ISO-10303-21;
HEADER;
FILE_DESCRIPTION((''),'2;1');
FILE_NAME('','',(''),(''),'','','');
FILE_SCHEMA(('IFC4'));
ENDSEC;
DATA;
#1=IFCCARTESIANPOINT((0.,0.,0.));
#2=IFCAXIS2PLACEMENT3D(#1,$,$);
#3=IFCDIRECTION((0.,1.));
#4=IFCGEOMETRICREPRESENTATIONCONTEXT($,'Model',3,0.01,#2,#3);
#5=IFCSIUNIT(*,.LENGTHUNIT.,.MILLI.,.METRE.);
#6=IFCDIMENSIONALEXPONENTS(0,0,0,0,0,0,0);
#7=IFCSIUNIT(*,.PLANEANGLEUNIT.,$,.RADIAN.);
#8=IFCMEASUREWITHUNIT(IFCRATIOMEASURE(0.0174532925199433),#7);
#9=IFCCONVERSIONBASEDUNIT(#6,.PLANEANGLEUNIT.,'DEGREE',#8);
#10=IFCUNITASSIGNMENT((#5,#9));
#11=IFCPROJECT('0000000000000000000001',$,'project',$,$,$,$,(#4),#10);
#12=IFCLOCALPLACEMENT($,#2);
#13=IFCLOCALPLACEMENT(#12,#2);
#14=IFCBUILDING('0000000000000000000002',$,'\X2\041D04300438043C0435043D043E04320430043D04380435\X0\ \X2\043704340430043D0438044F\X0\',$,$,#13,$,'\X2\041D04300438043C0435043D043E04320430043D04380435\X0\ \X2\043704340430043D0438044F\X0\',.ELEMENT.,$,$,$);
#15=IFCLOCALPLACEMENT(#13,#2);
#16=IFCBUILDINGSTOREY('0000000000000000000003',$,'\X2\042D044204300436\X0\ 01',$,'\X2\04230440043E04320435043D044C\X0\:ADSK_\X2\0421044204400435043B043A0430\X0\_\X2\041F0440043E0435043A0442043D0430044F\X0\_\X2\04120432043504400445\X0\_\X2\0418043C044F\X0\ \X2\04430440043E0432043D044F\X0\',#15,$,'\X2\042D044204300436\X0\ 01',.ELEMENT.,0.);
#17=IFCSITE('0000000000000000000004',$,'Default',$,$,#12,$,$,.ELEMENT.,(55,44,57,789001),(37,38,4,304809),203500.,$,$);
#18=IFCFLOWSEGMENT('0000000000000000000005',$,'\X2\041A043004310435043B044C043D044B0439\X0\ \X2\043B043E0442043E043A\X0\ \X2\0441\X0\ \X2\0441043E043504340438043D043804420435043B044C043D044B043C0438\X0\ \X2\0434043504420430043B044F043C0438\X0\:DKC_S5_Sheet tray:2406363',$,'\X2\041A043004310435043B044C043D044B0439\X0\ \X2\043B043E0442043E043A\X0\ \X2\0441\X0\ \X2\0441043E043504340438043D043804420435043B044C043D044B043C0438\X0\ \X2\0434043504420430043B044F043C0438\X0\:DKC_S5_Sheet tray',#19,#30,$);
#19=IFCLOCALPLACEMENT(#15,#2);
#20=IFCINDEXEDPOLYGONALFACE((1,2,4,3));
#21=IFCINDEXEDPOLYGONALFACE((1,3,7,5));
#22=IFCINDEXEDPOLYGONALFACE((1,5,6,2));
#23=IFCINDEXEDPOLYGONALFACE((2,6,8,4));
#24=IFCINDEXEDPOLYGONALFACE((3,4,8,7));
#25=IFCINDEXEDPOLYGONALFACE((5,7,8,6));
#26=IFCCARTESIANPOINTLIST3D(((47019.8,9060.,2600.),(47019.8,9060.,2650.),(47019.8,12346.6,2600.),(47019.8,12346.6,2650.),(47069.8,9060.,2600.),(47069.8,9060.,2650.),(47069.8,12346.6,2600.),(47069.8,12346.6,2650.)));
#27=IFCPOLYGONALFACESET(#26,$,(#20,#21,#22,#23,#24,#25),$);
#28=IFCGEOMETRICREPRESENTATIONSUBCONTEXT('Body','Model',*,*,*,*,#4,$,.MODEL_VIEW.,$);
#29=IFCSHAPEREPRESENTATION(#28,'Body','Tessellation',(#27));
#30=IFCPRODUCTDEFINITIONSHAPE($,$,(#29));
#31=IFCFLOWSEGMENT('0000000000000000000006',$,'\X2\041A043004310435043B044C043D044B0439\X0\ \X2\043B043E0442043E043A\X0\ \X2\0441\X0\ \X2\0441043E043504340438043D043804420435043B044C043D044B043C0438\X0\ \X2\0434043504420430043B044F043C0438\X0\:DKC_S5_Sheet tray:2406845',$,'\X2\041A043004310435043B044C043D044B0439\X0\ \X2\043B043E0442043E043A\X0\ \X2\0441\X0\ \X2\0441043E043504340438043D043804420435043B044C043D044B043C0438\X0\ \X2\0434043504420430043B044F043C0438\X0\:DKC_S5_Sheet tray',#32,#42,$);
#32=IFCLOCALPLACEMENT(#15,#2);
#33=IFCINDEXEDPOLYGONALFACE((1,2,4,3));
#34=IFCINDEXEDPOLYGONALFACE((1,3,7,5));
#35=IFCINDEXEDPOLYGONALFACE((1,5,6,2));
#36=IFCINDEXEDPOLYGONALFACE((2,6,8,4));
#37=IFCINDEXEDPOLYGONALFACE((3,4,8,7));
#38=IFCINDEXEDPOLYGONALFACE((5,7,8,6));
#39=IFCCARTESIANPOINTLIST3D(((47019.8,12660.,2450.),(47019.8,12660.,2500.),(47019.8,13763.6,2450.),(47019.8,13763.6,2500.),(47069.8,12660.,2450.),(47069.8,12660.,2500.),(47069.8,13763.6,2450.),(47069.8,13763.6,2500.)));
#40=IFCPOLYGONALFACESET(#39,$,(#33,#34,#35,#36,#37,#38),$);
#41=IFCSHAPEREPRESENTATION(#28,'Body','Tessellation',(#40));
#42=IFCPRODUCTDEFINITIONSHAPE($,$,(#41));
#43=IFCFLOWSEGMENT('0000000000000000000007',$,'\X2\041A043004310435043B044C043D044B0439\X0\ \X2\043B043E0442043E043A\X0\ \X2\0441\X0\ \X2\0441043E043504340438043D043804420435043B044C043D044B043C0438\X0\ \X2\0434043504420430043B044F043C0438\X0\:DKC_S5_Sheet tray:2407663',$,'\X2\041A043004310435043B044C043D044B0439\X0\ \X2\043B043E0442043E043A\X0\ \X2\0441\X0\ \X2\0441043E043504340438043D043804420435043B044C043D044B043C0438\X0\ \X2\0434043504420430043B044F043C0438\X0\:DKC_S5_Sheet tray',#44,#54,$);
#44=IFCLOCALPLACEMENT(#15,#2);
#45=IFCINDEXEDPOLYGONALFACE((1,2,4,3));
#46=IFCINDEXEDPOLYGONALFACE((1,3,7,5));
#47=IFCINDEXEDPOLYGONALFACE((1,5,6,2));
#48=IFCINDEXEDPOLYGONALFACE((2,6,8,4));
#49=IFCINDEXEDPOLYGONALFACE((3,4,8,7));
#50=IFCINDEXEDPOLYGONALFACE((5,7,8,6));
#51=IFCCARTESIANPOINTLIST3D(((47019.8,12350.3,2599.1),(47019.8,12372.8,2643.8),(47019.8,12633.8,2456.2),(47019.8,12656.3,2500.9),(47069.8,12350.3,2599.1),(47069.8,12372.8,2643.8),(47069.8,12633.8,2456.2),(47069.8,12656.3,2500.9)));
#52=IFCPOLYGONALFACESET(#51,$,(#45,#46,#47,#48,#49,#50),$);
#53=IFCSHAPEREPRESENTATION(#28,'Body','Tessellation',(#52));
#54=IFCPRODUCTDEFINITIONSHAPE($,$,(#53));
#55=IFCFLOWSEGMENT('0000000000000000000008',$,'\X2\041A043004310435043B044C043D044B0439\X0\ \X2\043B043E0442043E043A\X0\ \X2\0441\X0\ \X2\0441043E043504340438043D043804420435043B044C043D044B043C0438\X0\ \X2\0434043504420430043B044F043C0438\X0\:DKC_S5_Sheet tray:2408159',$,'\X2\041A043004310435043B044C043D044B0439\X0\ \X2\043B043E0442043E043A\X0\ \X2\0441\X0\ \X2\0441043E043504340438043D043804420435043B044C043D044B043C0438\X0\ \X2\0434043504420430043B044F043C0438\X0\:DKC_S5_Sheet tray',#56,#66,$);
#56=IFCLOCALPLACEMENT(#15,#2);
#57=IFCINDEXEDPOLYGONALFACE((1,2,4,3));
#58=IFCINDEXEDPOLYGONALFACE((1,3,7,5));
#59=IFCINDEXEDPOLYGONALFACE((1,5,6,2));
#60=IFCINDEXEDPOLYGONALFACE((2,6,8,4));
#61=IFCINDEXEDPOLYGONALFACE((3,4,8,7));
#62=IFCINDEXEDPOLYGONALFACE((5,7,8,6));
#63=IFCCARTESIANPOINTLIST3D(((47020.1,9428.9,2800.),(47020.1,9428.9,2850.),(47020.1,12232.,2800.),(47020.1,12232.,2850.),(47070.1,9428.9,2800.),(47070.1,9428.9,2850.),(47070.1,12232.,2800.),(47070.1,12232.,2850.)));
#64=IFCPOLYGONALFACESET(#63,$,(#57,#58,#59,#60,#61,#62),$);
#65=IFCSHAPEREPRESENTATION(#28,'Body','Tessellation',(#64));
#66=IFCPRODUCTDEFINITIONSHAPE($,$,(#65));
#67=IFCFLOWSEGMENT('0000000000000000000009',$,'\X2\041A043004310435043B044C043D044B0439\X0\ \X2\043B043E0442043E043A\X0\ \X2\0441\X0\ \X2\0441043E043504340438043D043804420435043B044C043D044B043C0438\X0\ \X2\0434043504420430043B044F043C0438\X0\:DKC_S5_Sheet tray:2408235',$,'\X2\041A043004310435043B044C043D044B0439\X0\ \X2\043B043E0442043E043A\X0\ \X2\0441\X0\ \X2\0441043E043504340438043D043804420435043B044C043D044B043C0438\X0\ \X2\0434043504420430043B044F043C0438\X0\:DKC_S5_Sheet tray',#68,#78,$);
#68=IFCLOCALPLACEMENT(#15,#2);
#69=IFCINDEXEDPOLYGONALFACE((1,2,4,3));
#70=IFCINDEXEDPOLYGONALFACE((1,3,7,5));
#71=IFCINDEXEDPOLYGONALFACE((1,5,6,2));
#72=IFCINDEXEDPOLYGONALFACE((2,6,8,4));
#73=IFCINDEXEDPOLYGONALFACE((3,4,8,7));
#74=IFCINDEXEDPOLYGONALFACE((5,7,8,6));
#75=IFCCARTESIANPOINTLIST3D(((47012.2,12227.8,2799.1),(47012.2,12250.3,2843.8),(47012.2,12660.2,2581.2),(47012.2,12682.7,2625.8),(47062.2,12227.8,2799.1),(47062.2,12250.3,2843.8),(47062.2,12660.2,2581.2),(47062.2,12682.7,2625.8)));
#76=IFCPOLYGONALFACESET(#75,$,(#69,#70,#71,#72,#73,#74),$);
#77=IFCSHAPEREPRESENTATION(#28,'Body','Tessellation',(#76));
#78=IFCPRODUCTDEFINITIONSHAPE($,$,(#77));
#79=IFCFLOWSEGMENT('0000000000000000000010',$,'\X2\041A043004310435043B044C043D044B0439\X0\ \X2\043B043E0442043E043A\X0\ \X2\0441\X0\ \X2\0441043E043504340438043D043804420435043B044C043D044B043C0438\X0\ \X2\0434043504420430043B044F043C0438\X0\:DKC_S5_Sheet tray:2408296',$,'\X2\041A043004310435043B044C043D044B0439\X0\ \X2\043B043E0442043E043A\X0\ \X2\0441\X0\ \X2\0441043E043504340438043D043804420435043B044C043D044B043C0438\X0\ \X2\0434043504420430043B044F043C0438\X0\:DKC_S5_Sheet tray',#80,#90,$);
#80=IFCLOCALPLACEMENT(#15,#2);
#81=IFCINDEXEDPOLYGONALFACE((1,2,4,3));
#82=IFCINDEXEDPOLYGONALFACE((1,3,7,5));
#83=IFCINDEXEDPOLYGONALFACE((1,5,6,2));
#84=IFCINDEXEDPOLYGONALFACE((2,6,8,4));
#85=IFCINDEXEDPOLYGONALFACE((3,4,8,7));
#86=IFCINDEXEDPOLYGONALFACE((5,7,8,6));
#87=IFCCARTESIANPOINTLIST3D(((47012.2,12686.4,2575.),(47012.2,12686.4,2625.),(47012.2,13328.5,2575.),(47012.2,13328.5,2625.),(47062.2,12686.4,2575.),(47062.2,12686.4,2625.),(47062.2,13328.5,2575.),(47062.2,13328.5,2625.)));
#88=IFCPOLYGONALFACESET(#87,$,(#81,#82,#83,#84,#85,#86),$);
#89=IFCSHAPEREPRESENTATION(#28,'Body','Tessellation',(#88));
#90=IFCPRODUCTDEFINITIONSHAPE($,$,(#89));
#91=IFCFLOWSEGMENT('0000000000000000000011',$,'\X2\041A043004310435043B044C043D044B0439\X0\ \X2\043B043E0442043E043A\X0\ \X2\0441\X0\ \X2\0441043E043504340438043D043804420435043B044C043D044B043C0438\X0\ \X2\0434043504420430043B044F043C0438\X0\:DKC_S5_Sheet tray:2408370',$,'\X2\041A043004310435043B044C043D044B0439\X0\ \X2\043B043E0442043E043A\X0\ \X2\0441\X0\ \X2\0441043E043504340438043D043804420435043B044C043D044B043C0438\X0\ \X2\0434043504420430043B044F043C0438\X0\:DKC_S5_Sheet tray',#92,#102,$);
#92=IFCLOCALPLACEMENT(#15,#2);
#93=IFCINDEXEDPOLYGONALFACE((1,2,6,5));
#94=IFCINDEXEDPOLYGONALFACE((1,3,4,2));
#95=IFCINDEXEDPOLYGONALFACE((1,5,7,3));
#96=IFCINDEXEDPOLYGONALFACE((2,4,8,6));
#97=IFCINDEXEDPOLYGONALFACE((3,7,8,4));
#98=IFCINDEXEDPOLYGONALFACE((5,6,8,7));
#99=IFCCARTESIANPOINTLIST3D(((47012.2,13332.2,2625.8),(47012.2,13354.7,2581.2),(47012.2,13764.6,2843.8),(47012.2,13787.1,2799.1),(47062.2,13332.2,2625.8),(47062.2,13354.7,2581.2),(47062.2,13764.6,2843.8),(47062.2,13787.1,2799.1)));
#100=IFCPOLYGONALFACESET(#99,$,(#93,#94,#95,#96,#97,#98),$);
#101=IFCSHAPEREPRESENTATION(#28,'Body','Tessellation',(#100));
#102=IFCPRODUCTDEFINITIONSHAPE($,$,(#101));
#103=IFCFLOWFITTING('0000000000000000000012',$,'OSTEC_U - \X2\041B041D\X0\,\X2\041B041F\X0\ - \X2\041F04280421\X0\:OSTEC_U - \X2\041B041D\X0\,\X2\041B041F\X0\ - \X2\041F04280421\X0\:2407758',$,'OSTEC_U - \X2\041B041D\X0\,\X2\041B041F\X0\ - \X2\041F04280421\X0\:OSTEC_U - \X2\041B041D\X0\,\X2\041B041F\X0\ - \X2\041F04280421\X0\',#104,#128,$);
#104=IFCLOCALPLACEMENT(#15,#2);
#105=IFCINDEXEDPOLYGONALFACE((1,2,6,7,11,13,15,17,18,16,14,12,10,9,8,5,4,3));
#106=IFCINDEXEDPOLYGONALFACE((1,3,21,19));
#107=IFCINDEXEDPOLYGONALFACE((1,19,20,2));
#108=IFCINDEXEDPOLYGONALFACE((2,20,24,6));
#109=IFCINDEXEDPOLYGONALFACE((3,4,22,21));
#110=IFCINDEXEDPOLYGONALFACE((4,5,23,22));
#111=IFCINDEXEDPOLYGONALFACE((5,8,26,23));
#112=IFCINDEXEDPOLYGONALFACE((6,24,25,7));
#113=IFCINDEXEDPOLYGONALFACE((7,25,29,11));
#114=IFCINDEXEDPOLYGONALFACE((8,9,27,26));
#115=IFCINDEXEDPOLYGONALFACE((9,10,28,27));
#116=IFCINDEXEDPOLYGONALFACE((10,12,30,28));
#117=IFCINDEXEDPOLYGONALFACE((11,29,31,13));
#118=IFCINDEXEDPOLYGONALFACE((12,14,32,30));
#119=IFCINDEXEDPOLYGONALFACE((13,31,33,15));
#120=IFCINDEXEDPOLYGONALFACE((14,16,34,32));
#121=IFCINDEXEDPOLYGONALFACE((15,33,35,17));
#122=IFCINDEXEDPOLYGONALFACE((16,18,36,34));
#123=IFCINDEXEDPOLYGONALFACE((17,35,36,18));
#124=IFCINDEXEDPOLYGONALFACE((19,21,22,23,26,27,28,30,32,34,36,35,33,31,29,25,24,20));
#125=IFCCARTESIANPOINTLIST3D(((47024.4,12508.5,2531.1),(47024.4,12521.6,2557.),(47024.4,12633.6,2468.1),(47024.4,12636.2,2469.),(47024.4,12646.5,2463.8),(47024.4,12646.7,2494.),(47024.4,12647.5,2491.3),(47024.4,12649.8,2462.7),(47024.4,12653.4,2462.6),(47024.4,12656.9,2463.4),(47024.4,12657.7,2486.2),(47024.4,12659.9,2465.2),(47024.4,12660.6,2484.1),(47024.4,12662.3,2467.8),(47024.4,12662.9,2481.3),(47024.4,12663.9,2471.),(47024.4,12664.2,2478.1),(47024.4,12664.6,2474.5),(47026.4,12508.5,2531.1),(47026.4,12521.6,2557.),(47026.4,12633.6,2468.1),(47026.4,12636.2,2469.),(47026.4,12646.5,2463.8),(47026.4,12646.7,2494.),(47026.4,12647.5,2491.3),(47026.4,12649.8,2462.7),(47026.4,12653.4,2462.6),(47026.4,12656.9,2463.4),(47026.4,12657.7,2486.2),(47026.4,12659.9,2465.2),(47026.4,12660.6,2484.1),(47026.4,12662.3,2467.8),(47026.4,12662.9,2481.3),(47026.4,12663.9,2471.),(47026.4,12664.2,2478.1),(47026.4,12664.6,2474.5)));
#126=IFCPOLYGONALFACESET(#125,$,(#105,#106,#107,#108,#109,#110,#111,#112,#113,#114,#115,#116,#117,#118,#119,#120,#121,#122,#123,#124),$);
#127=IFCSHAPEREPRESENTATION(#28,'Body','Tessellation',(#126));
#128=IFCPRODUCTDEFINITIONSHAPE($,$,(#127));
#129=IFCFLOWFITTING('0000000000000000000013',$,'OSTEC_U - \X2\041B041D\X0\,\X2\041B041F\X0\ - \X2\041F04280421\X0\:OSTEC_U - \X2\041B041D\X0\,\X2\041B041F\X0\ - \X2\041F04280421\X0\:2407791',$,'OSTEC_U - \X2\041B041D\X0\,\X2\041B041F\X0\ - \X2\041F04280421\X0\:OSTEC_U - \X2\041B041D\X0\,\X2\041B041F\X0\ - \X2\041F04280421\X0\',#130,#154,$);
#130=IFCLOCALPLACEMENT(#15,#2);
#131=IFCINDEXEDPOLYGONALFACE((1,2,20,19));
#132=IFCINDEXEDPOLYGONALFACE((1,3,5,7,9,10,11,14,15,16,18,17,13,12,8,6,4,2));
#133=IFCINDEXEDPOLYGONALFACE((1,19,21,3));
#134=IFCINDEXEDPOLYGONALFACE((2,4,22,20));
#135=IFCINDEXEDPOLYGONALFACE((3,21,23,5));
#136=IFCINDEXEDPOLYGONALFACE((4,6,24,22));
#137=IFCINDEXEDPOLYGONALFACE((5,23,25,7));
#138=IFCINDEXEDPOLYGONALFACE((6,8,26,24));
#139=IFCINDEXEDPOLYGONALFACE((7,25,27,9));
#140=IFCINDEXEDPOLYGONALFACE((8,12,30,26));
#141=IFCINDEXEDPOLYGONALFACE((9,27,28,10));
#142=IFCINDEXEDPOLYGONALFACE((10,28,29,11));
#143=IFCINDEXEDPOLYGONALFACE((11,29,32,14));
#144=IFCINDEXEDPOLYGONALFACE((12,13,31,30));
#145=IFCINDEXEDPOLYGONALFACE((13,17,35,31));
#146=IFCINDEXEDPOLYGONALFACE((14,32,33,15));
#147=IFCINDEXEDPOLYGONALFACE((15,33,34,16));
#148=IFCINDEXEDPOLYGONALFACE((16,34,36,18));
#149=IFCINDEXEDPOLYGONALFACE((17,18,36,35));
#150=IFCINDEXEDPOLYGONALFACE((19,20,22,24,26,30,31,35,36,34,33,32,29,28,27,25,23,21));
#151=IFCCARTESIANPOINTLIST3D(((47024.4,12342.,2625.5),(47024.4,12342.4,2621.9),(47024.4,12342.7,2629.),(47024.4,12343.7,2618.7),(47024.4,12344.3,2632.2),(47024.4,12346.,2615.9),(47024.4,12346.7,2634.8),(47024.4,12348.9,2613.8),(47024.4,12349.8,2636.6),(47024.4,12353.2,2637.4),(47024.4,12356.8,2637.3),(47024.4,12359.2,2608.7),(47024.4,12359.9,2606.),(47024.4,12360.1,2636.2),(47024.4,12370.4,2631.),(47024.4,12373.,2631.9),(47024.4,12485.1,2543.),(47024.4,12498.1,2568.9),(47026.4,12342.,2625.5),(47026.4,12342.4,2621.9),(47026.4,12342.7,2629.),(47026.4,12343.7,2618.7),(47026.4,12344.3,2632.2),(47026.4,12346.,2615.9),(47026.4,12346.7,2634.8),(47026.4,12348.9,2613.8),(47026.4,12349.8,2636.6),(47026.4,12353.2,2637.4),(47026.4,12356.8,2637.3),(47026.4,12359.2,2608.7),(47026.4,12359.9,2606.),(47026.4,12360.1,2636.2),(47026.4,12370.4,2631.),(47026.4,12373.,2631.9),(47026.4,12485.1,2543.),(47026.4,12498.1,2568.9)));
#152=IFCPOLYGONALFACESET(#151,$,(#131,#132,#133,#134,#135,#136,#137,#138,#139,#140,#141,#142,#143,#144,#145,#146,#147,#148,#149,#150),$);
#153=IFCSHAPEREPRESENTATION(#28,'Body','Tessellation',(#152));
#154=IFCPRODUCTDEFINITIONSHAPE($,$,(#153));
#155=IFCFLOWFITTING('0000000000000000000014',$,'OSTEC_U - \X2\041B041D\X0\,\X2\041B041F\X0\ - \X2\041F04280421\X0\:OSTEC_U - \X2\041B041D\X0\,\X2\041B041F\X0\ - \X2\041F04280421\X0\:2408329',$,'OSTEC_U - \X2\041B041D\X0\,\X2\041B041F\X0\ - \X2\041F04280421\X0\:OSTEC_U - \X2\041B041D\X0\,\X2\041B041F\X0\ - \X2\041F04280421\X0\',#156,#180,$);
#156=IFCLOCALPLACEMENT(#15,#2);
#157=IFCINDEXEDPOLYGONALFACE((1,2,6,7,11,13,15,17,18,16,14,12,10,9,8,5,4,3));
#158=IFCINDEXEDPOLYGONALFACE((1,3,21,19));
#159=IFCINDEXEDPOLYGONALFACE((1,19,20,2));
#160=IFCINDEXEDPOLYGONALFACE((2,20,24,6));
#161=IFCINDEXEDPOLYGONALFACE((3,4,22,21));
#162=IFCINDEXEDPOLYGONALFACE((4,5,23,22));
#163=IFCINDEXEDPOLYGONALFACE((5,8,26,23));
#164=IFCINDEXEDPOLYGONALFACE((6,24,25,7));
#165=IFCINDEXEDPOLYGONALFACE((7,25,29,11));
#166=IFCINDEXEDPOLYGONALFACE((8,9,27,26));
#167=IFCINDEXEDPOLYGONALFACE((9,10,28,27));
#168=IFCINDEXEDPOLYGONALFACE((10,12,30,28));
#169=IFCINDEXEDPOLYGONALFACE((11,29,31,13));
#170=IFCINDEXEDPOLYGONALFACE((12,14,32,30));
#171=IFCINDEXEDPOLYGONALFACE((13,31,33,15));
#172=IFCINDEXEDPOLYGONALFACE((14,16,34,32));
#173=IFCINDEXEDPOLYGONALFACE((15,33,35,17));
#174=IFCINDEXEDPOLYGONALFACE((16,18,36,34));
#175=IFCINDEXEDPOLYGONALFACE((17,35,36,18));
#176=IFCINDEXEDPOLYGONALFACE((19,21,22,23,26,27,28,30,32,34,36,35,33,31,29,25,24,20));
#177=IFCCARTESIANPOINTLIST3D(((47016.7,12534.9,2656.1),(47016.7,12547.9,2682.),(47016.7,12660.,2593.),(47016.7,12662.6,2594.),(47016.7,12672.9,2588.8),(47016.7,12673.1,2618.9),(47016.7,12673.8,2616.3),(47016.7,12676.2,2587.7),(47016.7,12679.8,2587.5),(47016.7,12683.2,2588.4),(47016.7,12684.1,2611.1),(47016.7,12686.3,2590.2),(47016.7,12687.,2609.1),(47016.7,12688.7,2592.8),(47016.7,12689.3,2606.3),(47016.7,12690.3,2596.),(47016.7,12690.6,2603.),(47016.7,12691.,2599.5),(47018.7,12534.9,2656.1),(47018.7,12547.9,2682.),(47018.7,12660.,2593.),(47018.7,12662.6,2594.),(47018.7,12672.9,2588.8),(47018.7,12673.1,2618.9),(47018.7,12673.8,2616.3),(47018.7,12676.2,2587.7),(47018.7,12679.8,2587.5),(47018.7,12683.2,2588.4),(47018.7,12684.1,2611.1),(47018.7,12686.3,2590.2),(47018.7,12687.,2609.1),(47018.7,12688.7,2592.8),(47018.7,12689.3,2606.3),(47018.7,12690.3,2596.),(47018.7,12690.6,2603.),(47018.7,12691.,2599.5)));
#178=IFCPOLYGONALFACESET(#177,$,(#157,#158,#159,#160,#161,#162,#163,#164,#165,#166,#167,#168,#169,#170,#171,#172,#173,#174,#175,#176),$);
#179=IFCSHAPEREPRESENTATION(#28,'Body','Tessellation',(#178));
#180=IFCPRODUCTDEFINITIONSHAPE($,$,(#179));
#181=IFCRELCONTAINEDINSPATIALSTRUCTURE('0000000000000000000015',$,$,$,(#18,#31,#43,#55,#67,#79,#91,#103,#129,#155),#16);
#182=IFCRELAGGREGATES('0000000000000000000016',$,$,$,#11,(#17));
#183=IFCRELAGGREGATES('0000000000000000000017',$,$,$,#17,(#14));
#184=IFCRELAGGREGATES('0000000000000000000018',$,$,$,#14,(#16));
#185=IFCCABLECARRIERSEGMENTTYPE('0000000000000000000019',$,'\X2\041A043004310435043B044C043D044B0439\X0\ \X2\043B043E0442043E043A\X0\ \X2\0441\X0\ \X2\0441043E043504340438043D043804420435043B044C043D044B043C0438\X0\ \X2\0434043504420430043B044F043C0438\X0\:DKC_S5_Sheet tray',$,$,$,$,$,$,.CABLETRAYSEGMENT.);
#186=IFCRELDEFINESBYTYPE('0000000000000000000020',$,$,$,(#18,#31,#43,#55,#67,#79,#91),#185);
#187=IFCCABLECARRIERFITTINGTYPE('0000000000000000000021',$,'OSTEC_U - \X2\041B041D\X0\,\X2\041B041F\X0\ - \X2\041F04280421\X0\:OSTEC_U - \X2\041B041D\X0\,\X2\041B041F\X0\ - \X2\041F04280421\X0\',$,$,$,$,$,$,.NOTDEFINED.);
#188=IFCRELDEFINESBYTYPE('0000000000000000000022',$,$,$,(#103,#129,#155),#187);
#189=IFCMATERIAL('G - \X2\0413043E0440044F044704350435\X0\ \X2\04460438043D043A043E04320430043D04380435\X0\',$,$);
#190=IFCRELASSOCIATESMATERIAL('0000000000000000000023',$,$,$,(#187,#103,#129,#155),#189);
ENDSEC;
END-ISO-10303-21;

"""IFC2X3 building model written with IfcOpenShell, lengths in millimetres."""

from ifc_helpers import new_model, entity, si_unit, converted_unit, direction, frame, frame_2d, origin, origin_2d_with_axis, place, context, subcontext, project, spatial, polyline, circle_curve, parameter, trimmed, segment, composite_curve, rectangle, outline, extrude, source, transform, mapped, material, type_object, type_shapes, element, save


model = new_model("IFC2X3")

# Units and contexts
model_context = context("Model", 3, precision=0.01, world=origin(), true_north=direction((0.0, 1.0)))
body_context = subcontext(model_context, "Body", "Model", "MODEL_VIEW")
ifc_project = project(units=[si_unit("LENGTHUNIT", "METRE", prefix="MILLI"), converted_unit("PLANEANGLEUNIT", "DEGREE", entity("IfcRatioMeasure", 0.0174532925199433), si_unit("PLANEANGLEUNIT", "RADIAN"), dimensions=[0, 0, 0, 0, 0, 0, 0])], contexts=[model_context])

# Site, building, storey
site_placement = place(None, origin())
site = spatial("IfcSite", under=ifc_project, at=site_placement, Name="Default", CompositionType="ELEMENT", RefLatitude=(55, 44, 57, 789001), RefLongitude=(37, 38, 4, 304809), RefElevation=203500.0)
building_placement = place(site_placement, origin())
building = spatial("IfcBuilding", under=site, at=building_placement, Name="Наименование здания", LongName="Наименование здания", CompositionType="ELEMENT")
storey_placement = place(building_placement, origin())
storey = spatial("IfcBuildingStorey", under=building, at=storey_placement, Name="Этаж 01", ObjectType="Уровень:ADSK_Стрелка_Проектная_Вверх_Имя уровня", LongName="Этаж 01", CompositionType="ELEMENT", Elevation=0.0)

# Flow segments
cable_carrier_segment_type = type_object("IfcCableCarrierSegmentType", Name="Кабельный лоток с соединительными деталями:DKC_S5_Sheet tray", PredefinedType="CABLETRAYSEGMENT")
flow_segment_1_placement = place(storey_placement, frame((47019.8, 9060.0, 2600.0)))
element("IfcFlowSegment", 1, at=flow_segment_1_placement, inside=storey, type_object=cable_carrier_segment_type, Name="Кабельный лоток с соединительными деталями:DKC_S5_Sheet tray:2406363", ObjectType="Кабельный лоток с соединительными деталями:DKC_S5_Sheet tray", context=body_context, shape_type="SweptSolid", body=[
    extrude(rectangle(XDim=3286.6, YDim=50.0, at=origin_2d_with_axis()), frame((25.0, 1643.3, 0.0), z_axis=(0.0, 0.0, 1.0), x_axis=(0.0, -1.0, 0.0)), (0.0, 0.0, 1.0), 50.0),
])
flow_segment_2_placement = place(storey_placement, frame((47019.8, 12660.0, 2450.0)))
element("IfcFlowSegment", 2, at=flow_segment_2_placement, inside=storey, type_object=cable_carrier_segment_type, Name="Кабельный лоток с соединительными деталями:DKC_S5_Sheet tray:2406845", ObjectType="Кабельный лоток с соединительными деталями:DKC_S5_Sheet tray", context=body_context, shape_type="SweptSolid", body=[
    extrude(rectangle(XDim=1103.6, YDim=50.0, at=origin_2d_with_axis()), frame((25.0, 551.8, 0.0), z_axis=(0.0, 0.0, 1.0), x_axis=(0.0, -1.0, 0.0)), (0.0, 0.0, 1.0), 50.0),
])
flow_segment_3_placement = place(storey_placement, frame((47019.8, 12350.3, 2456.2)))
element("IfcFlowSegment", 3, at=flow_segment_3_placement, inside=storey, type_object=cable_carrier_segment_type, Name="Кабельный лоток с соединительными деталями:DKC_S5_Sheet tray:2407663", ObjectType="Кабельный лоток с соединительными деталями:DKC_S5_Sheet tray", context=body_context, shape_type="SweptSolid", body=[
    extrude(rectangle(XDim=50.0, YDim=317.5, at=frame_2d((0.0, 0.0), x_axis=(0.0, 1.0))), frame((0.0, 153.0, 93.8), z_axis=(1.0, 0.0, 0.0), x_axis=(0.0, 0.892981, -0.450095)), (0.0, 0.0, 1.0), 50.0),
])
flow_segment_4_placement = place(storey_placement, frame((47020.1, 9429.0, 2800.0)))
element("IfcFlowSegment", 4, at=flow_segment_4_placement, inside=storey, type_object=cable_carrier_segment_type, Name="Кабельный лоток с соединительными деталями:DKC_S5_Sheet tray:2408159", ObjectType="Кабельный лоток с соединительными деталями:DKC_S5_Sheet tray", context=body_context, shape_type="SweptSolid", body=[
    extrude(rectangle(XDim=2803.0, YDim=50.0, at=origin_2d_with_axis()), frame((25.0, 1401.5, 0.0), z_axis=(0.0, 0.0, 1.0), x_axis=(0.0, 1.0, 0.0)), (0.0, 0.0, 1.0), 50.0),
])
flow_segment_5_placement = place(storey_placement, frame((47012.2, 12227.8, 2581.2)))
element("IfcFlowSegment", 5, at=flow_segment_5_placement, inside=storey, type_object=cable_carrier_segment_type, Name="Кабельный лоток с соединительными деталями:DKC_S5_Sheet tray:2408235", ObjectType="Кабельный лоток с соединительными деталями:DKC_S5_Sheet tray", context=body_context, shape_type="SweptSolid", body=[
    extrude(rectangle(XDim=50.0, YDim=484.2, at=frame_2d((0.0, 0.0), x_axis=(0.0, 1.0))), frame((0.0, 227.4, 131.3), z_axis=(1.0, 0.0, 0.0), x_axis=(0.0, 0.892981, -0.450095)), (0.0, 0.0, 1.0), 50.0),
])
flow_segment_6_placement = place(storey_placement, frame((47012.2, 12686.4, 2574.9)))
element("IfcFlowSegment", 6, at=flow_segment_6_placement, inside=storey, type_object=cable_carrier_segment_type, Name="Кабельный лоток с соединительными деталями:DKC_S5_Sheet tray:2408296", ObjectType="Кабельный лоток с соединительными деталями:DKC_S5_Sheet tray", context=body_context, shape_type="SweptSolid", body=[
    extrude(rectangle(XDim=642.1, YDim=50.0, at=origin_2d_with_axis()), frame((25.0, 321.1, 0.0), z_axis=(0.0, 0.0, 1.0), x_axis=(0.0, 1.0, 0.0)), (0.0, 0.0, 1.0), 50.0),
])
flow_segment_7_placement = place(storey_placement, frame((47012.2, 13332.2, 2581.2)))
element("IfcFlowSegment", 7, at=flow_segment_7_placement, inside=storey, type_object=cable_carrier_segment_type, Name="Кабельный лоток с соединительными деталями:DKC_S5_Sheet tray:2408370", ObjectType="Кабельный лоток с соединительными деталями:DKC_S5_Sheet tray", context=body_context, shape_type="SweptSolid", body=[
    extrude(rectangle(XDim=50.0, YDim=484.2, at=frame_2d((0.0, 0.0), x_axis=(0.0, 1.0))), frame((0.0, 227.4, 131.3), z_axis=(1.0, 0.0, 0.0), x_axis=(0.0, -0.892981, -0.450095)), (0.0, 0.0, 1.0), 50.0),
])

# Flow fittings
ifc_material_1 = material(Name="G - Горячее цинкование")
shared_shape_1 = source(origin(), body_context, "Body", "SweptSolid", [
    extrude(outline(composite_curve([segment(trimmed(circle_curve(frame_2d((-44.6, 0.0), x_axis=(1.0, 0.0)), 12.5), [parameter(90.0)], [parameter(270.0)], True, "PARAMETER"), True, "CONTINUOUS"), segment(polyline([(-44.6, -12.5), (-33.1, -12.5)]), True, "CONTINUOUS"), segment(polyline([(-33.1, -12.5), (-31.2, -14.5)]), True, "CONTINUOUS"), segment(polyline([(-31.2, -14.5), (108.9, -14.5)]), True, "CONTINUOUS"), segment(polyline([(108.9, -14.5), (108.9, 14.5)]), True, "CONTINUOUS"), segment(polyline([(108.9, 14.5), (-31.2, 14.5)]), True, "CONTINUOUS"), segment(polyline([(-31.2, 14.5), (-33.1, 12.5)]), True, "CONTINUOUS"), segment(polyline([(-33.1, 12.5), (-44.6, 12.5)]), True, "CONTINUOUS")], self_intersect=False)), frame((44.6, 0.0, 0.0), z_axis=(0.0, 0.0, -1.0), x_axis=(1.0, 0.0, 0.0)), (0.0, 0.0, -1.0), 2.0),
])
cable_carrier_fitting_type_1 = type_object("IfcCableCarrierFittingType", Name="OSTEC_U - ЛН,ЛП - ПШС:OSTEC_U - ЛН,ЛП - ПШС", PredefinedType="NOTDEFINED", material=ifc_material_1)
type_shapes(cable_carrier_fitting_type_1, [shared_shape_1])
flow_fitting_1_placement = place(storey_placement, frame((47026.4, 12652.1, 2475.0), z_axis=(-1.0, 0.0, 0.0), x_axis=(0.0, -0.892981, 0.450095)))
element("IfcFlowFitting", 8, at=flow_fitting_1_placement, inside=storey, type_object=cable_carrier_fitting_type_1, material=ifc_material_1, Name="OSTEC_U - ЛН,ЛП - ПШС:OSTEC_U - ЛН,ЛП - ПШС:2407758", ObjectType="OSTEC_U - ЛН,ЛП - ПШС:OSTEC_U - ЛН,ЛП - ПШС", context=body_context, shape_type="MappedRepresentation", body=[
    mapped(shared_shape_1, transform((0.0, 0.0, 0.0), scale=1.0)),
])
flow_fitting_2_placement = place(storey_placement, frame((47026.4, 12354.5, 2625.0), z_axis=(-1.0, 0.0, 0.0), x_axis=(0.0, 0.892981, -0.450095)))
element("IfcFlowFitting", 9, at=flow_fitting_2_placement, inside=storey, type_object=cable_carrier_fitting_type_1, material=ifc_material_1, Name="OSTEC_U - ЛН,ЛП - ПШС:OSTEC_U - ЛН,ЛП - ПШС:2407791", ObjectType="OSTEC_U - ЛН,ЛП - ПШС:OSTEC_U - ЛН,ЛП - ПШС", context=body_context, shape_type="MappedRepresentation", body=[
    mapped(shared_shape_1, transform((0.0, 0.0, 0.0), scale=1.0)),
])
flow_fitting_3_placement = place(storey_placement, frame((47018.7, 12678.5, 2599.9), z_axis=(-1.0, 0.0, 0.0), x_axis=(0.0, -0.892981, 0.450095)))
element("IfcFlowFitting", 10, at=flow_fitting_3_placement, inside=storey, type_object=cable_carrier_fitting_type_1, material=ifc_material_1, Name="OSTEC_U - ЛН,ЛП - ПШС:OSTEC_U - ЛН,ЛП - ПШС:2408329", ObjectType="OSTEC_U - ЛН,ЛП - ПШС:OSTEC_U - ЛН,ЛП - ПШС", context=body_context, shape_type="MappedRepresentation", body=[
    mapped(shared_shape_1, transform((0.0, 0.0, 0.0), scale=1.0)),
])

save(model, "model.ifc")
